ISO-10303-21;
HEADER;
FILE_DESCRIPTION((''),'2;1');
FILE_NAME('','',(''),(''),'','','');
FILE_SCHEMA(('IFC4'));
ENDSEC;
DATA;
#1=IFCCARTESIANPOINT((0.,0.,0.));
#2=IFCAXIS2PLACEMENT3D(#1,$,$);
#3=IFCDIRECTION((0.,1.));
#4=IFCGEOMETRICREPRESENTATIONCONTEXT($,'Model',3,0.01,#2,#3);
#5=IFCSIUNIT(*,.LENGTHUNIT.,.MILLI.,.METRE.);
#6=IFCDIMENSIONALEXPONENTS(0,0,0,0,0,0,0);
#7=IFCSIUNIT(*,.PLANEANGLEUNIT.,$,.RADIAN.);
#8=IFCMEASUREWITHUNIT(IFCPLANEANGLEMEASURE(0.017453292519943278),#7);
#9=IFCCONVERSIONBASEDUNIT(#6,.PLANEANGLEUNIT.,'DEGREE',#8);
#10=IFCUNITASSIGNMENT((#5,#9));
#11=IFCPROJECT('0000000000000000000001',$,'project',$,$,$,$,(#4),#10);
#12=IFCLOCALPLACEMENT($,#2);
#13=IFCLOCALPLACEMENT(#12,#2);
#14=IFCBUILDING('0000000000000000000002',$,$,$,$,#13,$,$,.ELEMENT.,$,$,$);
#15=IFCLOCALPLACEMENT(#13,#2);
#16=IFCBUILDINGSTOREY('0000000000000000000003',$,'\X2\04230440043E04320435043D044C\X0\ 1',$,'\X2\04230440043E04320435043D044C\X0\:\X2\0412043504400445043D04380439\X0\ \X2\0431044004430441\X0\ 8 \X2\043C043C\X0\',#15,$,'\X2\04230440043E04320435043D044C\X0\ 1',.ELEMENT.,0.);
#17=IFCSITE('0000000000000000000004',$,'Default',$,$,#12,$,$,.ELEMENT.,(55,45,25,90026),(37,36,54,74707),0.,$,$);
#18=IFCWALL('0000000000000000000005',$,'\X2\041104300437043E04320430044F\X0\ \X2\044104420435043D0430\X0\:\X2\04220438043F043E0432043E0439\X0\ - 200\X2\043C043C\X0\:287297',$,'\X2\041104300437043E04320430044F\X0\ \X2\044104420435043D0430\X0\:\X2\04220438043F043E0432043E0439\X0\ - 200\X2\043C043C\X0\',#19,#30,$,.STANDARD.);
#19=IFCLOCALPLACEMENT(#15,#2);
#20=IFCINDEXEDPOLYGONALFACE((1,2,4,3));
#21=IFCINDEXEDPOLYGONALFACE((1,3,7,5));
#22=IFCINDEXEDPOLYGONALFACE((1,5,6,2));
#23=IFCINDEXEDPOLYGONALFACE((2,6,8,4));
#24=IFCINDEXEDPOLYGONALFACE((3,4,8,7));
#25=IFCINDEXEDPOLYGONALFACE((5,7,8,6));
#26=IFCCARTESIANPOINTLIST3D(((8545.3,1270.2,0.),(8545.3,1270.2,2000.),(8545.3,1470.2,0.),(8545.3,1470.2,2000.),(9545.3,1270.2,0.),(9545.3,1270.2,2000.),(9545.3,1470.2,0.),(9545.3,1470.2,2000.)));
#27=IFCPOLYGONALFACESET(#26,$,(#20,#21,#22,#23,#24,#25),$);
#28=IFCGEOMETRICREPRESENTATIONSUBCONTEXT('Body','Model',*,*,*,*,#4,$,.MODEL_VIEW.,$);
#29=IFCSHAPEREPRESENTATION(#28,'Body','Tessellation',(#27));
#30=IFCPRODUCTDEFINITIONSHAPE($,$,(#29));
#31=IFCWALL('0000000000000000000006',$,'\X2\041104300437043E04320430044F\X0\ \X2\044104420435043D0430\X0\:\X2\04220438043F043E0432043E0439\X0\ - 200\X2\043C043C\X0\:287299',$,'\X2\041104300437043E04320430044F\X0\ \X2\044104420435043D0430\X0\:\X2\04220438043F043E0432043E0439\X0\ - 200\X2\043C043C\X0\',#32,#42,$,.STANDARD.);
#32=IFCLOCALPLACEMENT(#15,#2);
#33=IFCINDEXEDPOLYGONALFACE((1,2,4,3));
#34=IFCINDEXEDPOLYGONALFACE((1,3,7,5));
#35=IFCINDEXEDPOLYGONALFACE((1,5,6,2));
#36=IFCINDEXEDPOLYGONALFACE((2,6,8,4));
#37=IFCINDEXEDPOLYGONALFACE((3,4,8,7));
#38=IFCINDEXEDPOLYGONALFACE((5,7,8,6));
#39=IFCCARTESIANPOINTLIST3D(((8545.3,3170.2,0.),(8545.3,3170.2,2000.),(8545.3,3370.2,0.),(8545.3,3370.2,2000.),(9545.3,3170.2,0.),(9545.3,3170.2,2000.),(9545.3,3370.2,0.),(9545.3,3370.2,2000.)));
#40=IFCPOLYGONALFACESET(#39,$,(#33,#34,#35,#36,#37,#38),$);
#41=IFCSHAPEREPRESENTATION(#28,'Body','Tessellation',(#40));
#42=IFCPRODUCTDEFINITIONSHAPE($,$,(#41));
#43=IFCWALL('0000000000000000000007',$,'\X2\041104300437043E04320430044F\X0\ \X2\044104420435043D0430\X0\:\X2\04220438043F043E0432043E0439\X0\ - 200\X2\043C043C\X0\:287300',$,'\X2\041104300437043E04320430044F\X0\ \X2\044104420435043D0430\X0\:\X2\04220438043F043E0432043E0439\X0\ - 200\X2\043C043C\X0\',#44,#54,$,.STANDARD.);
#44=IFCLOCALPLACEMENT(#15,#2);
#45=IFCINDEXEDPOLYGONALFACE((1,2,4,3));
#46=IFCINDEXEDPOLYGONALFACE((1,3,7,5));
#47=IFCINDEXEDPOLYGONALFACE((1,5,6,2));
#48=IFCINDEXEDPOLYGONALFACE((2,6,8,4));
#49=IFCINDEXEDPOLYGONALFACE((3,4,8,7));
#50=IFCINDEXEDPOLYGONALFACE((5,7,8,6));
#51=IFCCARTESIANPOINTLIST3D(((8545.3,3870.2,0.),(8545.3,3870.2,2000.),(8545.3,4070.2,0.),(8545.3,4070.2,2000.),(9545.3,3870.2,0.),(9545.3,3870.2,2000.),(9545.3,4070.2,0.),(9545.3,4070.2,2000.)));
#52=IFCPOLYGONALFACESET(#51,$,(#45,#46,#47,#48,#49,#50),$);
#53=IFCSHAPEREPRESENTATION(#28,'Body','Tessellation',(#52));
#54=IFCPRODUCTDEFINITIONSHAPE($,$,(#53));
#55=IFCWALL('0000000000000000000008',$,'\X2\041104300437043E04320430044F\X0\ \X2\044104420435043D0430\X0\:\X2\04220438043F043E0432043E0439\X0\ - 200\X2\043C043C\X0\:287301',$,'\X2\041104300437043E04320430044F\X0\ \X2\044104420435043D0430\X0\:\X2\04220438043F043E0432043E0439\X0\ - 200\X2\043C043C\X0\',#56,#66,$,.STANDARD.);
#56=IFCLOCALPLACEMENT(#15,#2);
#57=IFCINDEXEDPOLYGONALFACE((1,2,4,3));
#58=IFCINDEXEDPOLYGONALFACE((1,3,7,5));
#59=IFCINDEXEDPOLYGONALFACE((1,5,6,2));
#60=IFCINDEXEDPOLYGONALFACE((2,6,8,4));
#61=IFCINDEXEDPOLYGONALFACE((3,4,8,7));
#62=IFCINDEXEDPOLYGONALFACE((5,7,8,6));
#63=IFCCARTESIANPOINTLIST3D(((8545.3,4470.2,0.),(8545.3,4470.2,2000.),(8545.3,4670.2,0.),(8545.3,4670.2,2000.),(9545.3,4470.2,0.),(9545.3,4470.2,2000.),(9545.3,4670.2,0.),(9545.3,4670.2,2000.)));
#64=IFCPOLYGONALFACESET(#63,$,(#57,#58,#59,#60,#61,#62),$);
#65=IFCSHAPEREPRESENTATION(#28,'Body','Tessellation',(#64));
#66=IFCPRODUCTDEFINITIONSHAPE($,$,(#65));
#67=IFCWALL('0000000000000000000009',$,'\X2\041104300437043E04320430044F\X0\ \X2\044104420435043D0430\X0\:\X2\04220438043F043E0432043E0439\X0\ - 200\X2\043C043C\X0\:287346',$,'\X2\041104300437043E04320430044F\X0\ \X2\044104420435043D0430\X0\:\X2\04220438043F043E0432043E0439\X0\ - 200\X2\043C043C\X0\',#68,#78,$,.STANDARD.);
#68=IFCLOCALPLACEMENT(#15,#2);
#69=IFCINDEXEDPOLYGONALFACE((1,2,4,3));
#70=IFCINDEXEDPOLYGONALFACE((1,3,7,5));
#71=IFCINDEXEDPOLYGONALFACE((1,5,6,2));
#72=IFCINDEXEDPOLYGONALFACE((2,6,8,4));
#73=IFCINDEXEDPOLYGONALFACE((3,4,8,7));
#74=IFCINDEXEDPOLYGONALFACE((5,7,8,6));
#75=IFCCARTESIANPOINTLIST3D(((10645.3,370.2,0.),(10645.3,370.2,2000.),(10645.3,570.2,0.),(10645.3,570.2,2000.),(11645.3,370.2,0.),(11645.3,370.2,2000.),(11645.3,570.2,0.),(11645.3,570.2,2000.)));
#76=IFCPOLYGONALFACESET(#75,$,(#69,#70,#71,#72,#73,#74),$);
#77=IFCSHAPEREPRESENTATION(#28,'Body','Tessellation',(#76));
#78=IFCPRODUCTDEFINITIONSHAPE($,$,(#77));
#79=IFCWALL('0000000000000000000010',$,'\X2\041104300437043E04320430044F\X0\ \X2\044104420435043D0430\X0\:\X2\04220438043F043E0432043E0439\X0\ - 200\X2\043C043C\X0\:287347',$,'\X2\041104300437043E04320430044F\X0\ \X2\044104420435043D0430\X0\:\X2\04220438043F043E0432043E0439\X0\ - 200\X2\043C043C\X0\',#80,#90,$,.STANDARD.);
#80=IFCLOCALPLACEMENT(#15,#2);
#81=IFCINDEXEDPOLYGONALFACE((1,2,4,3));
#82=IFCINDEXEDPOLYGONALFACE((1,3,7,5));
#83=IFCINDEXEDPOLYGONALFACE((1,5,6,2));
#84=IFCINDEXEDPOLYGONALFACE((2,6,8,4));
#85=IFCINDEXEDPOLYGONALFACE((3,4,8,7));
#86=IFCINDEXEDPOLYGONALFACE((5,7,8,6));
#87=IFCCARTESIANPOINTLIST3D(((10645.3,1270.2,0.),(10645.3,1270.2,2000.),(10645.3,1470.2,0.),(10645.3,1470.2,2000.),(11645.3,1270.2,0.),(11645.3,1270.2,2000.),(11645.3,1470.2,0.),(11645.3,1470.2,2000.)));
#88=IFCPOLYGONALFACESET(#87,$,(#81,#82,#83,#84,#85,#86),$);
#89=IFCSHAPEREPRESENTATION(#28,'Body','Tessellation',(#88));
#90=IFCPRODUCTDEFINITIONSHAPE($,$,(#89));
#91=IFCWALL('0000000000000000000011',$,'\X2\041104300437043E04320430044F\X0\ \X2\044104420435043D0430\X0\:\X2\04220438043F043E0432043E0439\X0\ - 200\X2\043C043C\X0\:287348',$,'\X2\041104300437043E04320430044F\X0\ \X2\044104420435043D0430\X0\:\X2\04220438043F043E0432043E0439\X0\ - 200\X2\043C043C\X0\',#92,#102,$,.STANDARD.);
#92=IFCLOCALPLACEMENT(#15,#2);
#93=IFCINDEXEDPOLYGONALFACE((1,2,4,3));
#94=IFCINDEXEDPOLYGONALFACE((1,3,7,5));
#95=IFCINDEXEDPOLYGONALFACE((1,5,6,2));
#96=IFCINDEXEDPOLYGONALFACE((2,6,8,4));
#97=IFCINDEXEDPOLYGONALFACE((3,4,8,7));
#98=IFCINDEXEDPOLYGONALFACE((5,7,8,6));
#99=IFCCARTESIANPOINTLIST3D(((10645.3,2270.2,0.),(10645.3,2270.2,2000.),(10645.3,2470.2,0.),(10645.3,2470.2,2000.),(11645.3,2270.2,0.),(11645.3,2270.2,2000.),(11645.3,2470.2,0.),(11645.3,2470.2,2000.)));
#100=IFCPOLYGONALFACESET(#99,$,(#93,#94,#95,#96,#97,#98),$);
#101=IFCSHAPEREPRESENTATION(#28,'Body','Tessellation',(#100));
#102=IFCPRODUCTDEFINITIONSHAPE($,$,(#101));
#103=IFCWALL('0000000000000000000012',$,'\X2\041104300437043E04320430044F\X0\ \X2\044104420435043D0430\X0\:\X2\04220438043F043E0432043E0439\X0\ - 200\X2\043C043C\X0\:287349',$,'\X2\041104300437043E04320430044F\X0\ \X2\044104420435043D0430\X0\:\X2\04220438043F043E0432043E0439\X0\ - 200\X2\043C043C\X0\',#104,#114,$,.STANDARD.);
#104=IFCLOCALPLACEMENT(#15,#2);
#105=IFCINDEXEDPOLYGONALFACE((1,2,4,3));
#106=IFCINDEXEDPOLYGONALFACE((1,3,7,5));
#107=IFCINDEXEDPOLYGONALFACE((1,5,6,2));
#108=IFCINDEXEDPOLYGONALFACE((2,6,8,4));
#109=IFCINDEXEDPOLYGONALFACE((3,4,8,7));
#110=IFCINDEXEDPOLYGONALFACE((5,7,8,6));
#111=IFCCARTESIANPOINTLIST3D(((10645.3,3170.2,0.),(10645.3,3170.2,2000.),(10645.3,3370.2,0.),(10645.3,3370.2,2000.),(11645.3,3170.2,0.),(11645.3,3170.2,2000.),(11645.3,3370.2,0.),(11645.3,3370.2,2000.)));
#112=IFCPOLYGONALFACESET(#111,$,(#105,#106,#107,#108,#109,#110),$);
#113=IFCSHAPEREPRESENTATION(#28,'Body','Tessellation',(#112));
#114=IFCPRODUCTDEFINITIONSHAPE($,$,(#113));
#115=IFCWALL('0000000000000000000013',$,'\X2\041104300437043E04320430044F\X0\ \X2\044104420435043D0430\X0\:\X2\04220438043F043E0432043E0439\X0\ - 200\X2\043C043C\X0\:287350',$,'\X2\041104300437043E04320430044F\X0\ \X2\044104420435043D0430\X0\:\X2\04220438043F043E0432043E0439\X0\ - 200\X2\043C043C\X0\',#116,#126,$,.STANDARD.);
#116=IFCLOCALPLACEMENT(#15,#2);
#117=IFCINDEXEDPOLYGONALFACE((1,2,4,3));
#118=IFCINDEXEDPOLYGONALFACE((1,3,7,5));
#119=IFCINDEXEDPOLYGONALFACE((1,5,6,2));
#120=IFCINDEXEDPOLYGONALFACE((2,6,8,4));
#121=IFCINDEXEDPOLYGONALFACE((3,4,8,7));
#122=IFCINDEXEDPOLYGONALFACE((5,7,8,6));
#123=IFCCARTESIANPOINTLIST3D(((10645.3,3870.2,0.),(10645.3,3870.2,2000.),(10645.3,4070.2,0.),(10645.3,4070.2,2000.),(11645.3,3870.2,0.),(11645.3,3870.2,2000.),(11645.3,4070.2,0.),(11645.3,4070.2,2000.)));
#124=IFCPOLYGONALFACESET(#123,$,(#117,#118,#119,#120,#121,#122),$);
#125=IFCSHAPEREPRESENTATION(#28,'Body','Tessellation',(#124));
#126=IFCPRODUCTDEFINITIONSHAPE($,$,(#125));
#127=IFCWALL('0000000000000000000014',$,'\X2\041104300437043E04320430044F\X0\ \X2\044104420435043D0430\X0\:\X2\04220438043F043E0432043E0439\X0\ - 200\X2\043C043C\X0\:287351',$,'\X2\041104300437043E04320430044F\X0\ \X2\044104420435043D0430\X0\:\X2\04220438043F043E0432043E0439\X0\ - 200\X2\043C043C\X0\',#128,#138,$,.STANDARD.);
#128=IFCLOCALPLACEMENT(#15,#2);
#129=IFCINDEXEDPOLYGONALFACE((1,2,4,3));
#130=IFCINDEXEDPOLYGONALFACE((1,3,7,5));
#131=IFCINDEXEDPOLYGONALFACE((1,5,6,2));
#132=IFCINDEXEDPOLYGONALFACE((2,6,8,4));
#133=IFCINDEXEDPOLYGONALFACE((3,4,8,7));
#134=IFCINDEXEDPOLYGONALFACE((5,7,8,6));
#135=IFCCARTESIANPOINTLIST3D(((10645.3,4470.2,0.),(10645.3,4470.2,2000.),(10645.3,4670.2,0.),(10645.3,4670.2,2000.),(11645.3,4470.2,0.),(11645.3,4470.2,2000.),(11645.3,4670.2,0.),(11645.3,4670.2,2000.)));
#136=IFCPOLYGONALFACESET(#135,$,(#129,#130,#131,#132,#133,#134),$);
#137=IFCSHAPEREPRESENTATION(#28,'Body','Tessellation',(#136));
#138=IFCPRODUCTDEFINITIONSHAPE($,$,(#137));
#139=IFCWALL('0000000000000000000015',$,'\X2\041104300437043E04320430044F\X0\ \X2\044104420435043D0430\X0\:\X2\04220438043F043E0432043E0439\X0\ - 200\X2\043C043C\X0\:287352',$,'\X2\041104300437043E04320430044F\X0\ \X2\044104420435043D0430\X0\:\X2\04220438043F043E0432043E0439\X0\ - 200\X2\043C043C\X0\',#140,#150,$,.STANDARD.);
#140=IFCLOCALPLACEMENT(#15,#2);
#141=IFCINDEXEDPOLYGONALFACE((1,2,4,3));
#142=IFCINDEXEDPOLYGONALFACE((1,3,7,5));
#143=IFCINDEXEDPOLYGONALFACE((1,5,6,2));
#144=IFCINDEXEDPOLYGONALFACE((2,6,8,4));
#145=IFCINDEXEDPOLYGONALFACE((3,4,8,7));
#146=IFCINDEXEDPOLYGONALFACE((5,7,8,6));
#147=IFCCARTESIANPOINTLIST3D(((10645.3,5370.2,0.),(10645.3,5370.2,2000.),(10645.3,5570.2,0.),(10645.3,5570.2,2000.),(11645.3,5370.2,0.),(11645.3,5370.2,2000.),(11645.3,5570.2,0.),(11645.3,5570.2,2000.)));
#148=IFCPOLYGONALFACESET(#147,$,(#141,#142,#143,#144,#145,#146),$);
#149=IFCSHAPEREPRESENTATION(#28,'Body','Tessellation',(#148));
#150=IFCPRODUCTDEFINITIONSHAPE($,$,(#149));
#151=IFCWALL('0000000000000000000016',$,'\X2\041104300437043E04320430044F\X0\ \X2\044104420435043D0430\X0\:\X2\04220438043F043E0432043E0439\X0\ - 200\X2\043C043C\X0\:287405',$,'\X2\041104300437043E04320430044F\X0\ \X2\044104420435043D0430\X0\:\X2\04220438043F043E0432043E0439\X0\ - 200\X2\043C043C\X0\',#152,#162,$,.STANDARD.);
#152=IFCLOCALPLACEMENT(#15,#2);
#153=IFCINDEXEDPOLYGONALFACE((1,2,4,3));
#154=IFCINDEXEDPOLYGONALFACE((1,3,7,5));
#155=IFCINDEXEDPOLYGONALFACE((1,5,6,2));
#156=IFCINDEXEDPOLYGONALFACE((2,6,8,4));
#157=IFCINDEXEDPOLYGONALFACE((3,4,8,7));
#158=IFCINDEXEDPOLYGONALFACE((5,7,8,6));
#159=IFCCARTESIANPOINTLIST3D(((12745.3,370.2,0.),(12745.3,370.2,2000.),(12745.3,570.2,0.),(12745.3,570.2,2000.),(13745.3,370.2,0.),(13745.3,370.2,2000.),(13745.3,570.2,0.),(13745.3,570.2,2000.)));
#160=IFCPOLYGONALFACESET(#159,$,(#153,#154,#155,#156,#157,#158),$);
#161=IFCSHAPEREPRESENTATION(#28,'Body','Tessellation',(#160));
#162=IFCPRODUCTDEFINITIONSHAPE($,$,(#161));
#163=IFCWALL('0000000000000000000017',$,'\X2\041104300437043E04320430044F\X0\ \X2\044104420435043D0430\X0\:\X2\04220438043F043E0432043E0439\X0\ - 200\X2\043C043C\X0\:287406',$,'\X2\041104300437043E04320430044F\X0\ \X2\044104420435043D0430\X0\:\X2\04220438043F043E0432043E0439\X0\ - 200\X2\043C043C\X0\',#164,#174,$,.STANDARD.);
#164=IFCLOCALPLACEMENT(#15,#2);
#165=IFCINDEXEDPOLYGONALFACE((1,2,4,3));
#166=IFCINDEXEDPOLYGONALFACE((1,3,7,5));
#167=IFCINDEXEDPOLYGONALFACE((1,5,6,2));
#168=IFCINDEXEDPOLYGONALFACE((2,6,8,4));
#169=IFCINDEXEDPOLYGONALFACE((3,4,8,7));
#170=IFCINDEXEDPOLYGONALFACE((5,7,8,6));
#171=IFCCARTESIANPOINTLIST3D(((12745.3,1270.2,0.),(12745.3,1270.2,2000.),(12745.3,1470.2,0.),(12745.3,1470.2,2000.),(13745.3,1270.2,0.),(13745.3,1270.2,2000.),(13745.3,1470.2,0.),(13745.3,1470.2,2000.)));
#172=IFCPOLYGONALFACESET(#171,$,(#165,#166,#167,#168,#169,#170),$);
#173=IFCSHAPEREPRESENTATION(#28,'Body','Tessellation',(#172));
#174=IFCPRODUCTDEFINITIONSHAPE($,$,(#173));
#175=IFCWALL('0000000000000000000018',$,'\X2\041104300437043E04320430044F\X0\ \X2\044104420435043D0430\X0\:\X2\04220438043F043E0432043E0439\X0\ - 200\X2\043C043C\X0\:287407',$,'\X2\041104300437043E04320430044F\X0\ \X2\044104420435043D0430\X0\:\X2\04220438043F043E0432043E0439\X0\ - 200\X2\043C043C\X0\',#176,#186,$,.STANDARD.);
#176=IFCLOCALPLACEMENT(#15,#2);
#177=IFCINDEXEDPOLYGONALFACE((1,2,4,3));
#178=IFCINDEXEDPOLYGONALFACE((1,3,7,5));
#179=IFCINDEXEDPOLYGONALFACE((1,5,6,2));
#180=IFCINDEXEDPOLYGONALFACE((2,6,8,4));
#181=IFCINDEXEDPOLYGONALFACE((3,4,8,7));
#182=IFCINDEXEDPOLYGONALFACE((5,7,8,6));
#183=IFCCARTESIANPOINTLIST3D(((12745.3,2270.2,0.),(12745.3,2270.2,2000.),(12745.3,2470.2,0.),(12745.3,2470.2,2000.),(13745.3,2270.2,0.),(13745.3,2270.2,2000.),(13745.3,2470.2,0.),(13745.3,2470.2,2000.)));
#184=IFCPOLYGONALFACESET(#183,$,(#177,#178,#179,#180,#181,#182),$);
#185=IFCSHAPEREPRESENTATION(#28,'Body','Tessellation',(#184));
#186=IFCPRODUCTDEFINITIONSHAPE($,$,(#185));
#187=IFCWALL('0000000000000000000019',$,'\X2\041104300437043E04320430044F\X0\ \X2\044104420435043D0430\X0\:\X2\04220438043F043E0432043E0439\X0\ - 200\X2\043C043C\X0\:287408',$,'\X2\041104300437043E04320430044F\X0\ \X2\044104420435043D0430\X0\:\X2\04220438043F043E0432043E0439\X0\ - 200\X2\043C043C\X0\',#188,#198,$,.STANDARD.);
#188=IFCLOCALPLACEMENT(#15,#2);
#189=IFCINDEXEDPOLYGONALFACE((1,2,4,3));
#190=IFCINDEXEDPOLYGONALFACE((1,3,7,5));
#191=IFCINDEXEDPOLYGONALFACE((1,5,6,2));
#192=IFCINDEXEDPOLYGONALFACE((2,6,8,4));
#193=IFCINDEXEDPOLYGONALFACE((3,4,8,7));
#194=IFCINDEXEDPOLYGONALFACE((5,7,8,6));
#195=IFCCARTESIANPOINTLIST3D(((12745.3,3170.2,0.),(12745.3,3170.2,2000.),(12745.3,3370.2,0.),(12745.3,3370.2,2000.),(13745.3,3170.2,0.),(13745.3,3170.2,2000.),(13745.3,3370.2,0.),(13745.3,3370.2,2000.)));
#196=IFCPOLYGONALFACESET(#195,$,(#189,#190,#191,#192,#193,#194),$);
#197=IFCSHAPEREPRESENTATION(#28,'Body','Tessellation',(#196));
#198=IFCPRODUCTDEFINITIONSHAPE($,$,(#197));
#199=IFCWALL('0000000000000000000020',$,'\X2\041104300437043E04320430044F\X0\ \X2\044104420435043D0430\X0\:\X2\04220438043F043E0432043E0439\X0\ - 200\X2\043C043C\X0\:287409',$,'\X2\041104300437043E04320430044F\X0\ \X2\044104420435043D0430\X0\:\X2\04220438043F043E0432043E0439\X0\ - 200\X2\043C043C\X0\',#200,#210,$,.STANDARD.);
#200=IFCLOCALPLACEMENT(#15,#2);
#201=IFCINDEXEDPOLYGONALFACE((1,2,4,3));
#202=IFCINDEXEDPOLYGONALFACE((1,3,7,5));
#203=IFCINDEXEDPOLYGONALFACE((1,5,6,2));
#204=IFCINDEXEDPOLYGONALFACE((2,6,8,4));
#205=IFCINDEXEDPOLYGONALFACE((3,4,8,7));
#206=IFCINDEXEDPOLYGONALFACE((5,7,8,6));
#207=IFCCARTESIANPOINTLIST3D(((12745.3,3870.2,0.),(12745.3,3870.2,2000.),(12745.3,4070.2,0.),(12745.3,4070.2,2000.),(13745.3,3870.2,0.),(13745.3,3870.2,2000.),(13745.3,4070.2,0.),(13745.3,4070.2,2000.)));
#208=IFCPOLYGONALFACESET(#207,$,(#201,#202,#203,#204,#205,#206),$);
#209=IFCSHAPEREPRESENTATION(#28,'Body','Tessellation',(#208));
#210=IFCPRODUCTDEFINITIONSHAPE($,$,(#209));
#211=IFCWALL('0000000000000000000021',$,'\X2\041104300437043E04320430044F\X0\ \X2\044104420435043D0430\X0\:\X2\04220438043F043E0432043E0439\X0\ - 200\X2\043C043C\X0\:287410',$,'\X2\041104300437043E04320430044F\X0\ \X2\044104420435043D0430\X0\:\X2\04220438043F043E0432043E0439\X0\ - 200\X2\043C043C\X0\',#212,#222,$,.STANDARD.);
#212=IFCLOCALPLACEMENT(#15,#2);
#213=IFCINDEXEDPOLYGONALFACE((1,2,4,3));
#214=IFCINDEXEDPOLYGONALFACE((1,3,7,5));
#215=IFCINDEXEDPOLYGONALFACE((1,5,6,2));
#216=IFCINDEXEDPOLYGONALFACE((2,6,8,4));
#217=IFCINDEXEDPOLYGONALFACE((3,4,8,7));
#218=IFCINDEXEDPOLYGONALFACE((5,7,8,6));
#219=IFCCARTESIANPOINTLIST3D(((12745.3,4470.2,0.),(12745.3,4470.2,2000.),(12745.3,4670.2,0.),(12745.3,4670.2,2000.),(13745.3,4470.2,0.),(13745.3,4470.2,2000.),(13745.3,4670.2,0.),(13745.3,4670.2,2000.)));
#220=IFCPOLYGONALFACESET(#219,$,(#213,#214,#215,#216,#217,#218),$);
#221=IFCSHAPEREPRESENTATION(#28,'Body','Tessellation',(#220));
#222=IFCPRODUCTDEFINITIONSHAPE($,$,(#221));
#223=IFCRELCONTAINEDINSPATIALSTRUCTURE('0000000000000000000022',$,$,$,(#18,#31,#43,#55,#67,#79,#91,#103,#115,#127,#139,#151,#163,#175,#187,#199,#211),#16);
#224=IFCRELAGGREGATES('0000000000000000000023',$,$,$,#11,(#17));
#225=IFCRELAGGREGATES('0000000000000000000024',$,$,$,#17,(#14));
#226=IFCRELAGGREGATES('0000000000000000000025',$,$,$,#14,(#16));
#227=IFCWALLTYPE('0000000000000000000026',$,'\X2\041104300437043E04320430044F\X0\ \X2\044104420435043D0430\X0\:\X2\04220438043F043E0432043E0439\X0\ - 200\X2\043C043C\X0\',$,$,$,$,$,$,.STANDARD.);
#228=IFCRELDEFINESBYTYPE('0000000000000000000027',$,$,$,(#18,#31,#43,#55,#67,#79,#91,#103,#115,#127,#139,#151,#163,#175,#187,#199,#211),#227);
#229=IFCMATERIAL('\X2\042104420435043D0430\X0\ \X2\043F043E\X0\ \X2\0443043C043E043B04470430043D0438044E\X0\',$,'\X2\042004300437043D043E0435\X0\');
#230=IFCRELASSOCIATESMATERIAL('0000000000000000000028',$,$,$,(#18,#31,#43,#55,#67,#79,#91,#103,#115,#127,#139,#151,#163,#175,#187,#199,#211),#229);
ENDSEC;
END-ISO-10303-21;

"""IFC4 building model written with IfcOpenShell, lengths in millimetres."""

from ifc_helpers import new_model, entity, si_unit, converted_unit, direction, frame, origin, place, context, subcontext, project, spatial, indexed_curve, outline, extrude, material, type_object, element, save


model = new_model("IFC4")

# Units and contexts
model_context = context("Model", 3, precision=0.01, world=origin(), true_north=direction((0.0, 1.0)))
body_context = subcontext(model_context, "Body", "Model", "MODEL_VIEW")
ifc_project = project(units=[si_unit("LENGTHUNIT", "METRE", prefix="MILLI"), converted_unit("PLANEANGLEUNIT", "DEGREE", entity("IfcPlaneAngleMeasure", 0.017453292519943278), si_unit("PLANEANGLEUNIT", "RADIAN"), dimensions=[0, 0, 0, 0, 0, 0, 0])], contexts=[model_context])

# Site, building, storey
site_placement = place(None, origin())
site = spatial("IfcSite", under=ifc_project, at=site_placement, Name="Default", CompositionType="ELEMENT", RefLatitude=(55, 45, 25, 90026), RefLongitude=(37, 36, 54, 74707), RefElevation=0.0)
building_placement = place(site_placement, origin())
building = spatial("IfcBuilding", under=site, at=building_placement, CompositionType="ELEMENT")
storey_placement = place(building_placement, origin())
storey = spatial("IfcBuildingStorey", under=building, at=storey_placement, Name="Уровень 1", ObjectType="Уровень:Верхний брус 8 мм", LongName="Уровень 1", CompositionType="ELEMENT", Elevation=0.0)

# Walls
ifc_material = material(Name="Стена по умолчанию", Category="Разное")
wall_type = type_object("IfcWallType", Name="Базовая стена:Типовой - 200мм", PredefinedType="STANDARD")
wall_1_placement = place(storey_placement, frame((8545.3, 1370.2, 0.0)))
element("IfcWall", 1, at=wall_1_placement, inside=storey, type_object=wall_type, material=ifc_material, Name="Базовая стена:Типовой - 200мм:287297", ObjectType="Базовая стена:Типовой - 200мм", PredefinedType="STANDARD", context=body_context, shape_type="SweptSolid", body=[
    extrude(outline(indexed_curve([(1000.0, 100.0), (0.0, 100.0), (0.0, -100.0), (1000.0, -100.0), (1000.0, 100.0)], self_intersect=False)), origin(), (0.0, 0.0, 1.0), 2000.0),
])
for number, where, name in (
    (2, (8545.3, 3270.2, 0.0), "Базовая стена:Типовой - 200мм:287299"),
    (3, (8545.3, 3970.2, 0.0), "Базовая стена:Типовой - 200мм:287300"),
):
    element("IfcWall", number, at=place(storey_placement, frame(where)), inside=storey, type_object=wall_type, material=ifc_material, Name=name, ObjectType="Базовая стена:Типовой - 200мм", PredefinedType="STANDARD", context=body_context, shape_type="SweptSolid", body=[
        extrude(outline(indexed_curve([(1000.0, 100.0), (0.0, 100.0), (0.0, -100.0), (1000.0, -100.0), (1000.0, 100.0)], self_intersect=False)), origin(), (0.0, 0.0, 1.0), 2000.0),
    ])
wall_2_placement = place(storey_placement, frame((8545.3, 4570.2, 0.0)))
element("IfcWall", 4, at=wall_2_placement, inside=storey, type_object=wall_type, material=ifc_material, Name="Базовая стена:Типовой - 200мм:287301", ObjectType="Базовая стена:Типовой - 200мм", PredefinedType="STANDARD", context=body_context, shape_type="SweptSolid", body=[
    extrude(outline(indexed_curve([(1000.0, 100.0), (0.0, 100.0), (0.0, -100.0), (1000.0, -100.0), (1000.0, 100.0)], self_intersect=False)), origin(), (0.0, 0.0, 1.0), 2000.0),
])
for number, where, name in (
    (5, (10645.3, 470.2, 0.0), "Базовая стена:Типовой - 200мм:287346"),
    (6, (10645.3, 1370.2, 0.0), "Базовая стена:Типовой - 200мм:287347"),
):
    element("IfcWall", number, at=place(storey_placement, frame(where)), inside=storey, type_object=wall_type, material=ifc_material, Name=name, ObjectType="Базовая стена:Типовой - 200мм", PredefinedType="STANDARD", context=body_context, shape_type="SweptSolid", body=[
        extrude(outline(indexed_curve([(1000.0, 100.0), (0.0, 100.0), (0.0, -100.0), (1000.0, -100.0), (1000.0, 100.0)], self_intersect=False)), origin(), (0.0, 0.0, 1.0), 2000.0),
    ])
for number, where, name in (
    (7, (10645.3, 2370.2, 0.0), "Базовая стена:Типовой - 200мм:287348"),
    (8, (10645.3, 3270.2, 0.0), "Базовая стена:Типовой - 200мм:287349"),
    (9, (10645.3, 3970.2, 0.0), "Базовая стена:Типовой - 200мм:287350"),
):
    element("IfcWall", number, at=place(storey_placement, frame(where)), inside=storey, type_object=wall_type, material=ifc_material, Name=name, ObjectType="Базовая стена:Типовой - 200мм", PredefinedType="STANDARD", context=body_context, shape_type="SweptSolid", body=[
        extrude(outline(indexed_curve([(1000.0, 100.0), (0.0, 100.0), (0.0, -100.0), (1000.0, -100.0), (1000.0, 100.0)], self_intersect=False)), origin(), (0.0, 0.0, 1.0), 2000.0),
    ])
for number, where, name in (
    (10, (10645.3, 4570.2, 0.0), "Базовая стена:Типовой - 200мм:287351"),
    (11, (10645.3, 5470.2, 0.0), "Базовая стена:Типовой - 200мм:287352"),
    (12, (12745.3, 470.2, 0.0), "Базовая стена:Типовой - 200мм:287405"),
    (13, (12745.3, 1370.2, 0.0), "Базовая стена:Типовой - 200мм:287406"),
):
    element("IfcWall", number, at=place(storey_placement, frame(where)), inside=storey, type_object=wall_type, material=ifc_material, Name=name, ObjectType="Базовая стена:Типовой - 200мм", PredefinedType="STANDARD", context=body_context, shape_type="SweptSolid", body=[
        extrude(outline(indexed_curve([(1000.0, 100.0), (0.0, 100.0), (0.0, -100.0), (1000.0, -100.0), (1000.0, 100.0)], self_intersect=False)), origin(), (0.0, 0.0, 1.0), 2000.0),
    ])
for number, where, name in (
    (14, (12745.3, 2370.2, 0.0), "Базовая стена:Типовой - 200мм:287407"),
    (15, (12745.3, 3270.2, 0.0), "Базовая стена:Типовой - 200мм:287408"),
    (16, (12745.3, 3970.2, 0.0), "Базовая стена:Типовой - 200мм:287409"),
):
    element("IfcWall", number, at=place(storey_placement, frame(where)), inside=storey, type_object=wall_type, material=ifc_material, Name=name, ObjectType="Базовая стена:Типовой - 200мм", PredefinedType="STANDARD", context=body_context, shape_type="SweptSolid", body=[
        extrude(outline(indexed_curve([(1000.0, 100.0), (0.0, 100.0), (0.0, -100.0), (1000.0, -100.0), (1000.0, 100.0)], self_intersect=False)), origin(), (0.0, 0.0, 1.0), 2000.0),
    ])
for number, where, name in (
    (17, (12745.3, 4570.2, 0.0), "Базовая стена:Типовой - 200мм:287410"),
):
    element("IfcWall", number, at=place(storey_placement, frame(where)), inside=storey, type_object=wall_type, material=ifc_material, Name=name, ObjectType="Базовая стена:Типовой - 200мм", PredefinedType="STANDARD", context=body_context, shape_type="SweptSolid", body=[
        extrude(outline(indexed_curve([(1000.0, 100.0), (0.0, 100.0), (0.0, -100.0), (1000.0, -100.0), (1000.0, 100.0)], self_intersect=False)), origin(), (0.0, 0.0, 1.0), 2000.0),
    ])

save(model, "model.ifc")
